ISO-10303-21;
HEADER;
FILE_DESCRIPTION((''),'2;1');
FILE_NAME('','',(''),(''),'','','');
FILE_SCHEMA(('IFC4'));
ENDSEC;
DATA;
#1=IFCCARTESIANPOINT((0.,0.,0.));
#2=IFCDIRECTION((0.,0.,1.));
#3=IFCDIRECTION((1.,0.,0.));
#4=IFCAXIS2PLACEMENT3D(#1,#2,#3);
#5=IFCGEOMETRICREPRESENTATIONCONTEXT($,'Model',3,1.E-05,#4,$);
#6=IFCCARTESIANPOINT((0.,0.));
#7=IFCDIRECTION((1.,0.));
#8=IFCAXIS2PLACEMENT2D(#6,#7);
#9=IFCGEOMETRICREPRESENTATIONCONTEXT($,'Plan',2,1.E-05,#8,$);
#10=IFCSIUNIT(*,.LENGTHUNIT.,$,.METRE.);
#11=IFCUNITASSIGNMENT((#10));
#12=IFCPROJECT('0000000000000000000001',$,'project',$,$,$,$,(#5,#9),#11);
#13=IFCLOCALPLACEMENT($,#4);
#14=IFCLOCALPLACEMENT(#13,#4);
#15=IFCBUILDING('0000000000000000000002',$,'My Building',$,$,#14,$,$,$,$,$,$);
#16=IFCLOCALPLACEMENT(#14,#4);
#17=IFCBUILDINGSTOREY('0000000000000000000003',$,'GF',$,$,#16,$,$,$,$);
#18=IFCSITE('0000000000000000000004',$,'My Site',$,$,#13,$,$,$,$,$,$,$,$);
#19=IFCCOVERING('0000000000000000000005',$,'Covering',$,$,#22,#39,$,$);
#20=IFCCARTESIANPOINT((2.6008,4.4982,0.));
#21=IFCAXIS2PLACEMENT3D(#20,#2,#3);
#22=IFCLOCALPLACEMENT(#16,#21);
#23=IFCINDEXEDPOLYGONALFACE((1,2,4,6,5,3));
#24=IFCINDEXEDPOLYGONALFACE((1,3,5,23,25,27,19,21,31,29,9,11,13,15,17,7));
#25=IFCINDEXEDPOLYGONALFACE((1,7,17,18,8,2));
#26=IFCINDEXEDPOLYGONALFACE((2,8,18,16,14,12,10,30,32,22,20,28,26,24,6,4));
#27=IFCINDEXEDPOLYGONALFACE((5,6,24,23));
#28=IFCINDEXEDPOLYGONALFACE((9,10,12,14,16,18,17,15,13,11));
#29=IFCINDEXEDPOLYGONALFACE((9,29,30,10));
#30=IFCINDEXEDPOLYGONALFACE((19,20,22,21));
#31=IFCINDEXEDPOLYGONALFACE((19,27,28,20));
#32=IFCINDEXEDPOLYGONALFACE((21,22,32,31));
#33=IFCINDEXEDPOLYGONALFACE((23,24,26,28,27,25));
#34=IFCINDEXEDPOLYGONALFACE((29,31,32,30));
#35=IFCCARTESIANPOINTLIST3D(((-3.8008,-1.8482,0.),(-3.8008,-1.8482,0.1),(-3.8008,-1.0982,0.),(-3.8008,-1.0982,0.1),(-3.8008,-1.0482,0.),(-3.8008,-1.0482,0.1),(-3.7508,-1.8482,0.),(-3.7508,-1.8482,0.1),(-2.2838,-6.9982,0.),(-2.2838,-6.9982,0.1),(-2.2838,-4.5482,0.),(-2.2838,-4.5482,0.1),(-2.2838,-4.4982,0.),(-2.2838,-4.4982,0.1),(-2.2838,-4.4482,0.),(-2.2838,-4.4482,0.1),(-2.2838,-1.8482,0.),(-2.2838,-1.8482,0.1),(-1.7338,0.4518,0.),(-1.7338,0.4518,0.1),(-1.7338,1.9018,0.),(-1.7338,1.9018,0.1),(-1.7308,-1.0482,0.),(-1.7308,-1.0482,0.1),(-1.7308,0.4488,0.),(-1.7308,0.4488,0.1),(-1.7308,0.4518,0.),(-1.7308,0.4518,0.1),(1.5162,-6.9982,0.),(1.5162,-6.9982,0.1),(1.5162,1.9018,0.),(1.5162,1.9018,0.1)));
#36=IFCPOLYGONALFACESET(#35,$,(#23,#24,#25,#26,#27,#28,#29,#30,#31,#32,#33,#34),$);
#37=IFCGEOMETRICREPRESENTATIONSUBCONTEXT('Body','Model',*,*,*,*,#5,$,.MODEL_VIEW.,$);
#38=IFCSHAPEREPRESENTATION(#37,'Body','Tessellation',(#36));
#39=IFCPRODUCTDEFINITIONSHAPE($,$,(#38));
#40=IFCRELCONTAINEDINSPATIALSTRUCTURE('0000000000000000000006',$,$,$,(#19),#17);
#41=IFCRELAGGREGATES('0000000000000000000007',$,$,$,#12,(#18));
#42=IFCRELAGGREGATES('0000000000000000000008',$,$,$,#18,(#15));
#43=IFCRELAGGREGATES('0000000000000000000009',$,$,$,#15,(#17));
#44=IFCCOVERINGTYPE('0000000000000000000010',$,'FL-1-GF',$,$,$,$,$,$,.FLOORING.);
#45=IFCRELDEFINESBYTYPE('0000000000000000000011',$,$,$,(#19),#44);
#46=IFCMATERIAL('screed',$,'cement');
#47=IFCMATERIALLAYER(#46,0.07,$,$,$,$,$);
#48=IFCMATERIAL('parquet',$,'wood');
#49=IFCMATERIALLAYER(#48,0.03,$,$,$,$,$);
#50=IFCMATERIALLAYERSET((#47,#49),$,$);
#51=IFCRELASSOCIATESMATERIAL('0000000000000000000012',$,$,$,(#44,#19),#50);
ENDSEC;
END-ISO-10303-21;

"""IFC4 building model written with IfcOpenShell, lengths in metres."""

from ifc_helpers import new_model, si_unit, frame, origin_with_axes, origin_2d_with_axis, place, context, subcontext, project, spatial, line, indexed_curve, outline, extrude, material, layer, layer_set, layer_usage, type_object, element, save


model = new_model("IFC4")

# Units and contexts
model_context = context("Model", 3, precision=1e-05, world=origin_with_axes())
plan_context = context("Plan", 2, precision=1e-05, world=origin_2d_with_axis())
body_context_1 = subcontext(model_context, "Body", "Model", "MODEL_VIEW")
ifc_project = project(units=[si_unit("LENGTHUNIT", "METRE")], contexts=[model_context, plan_context])

# Site, building, storey
site_placement = place(None, origin_with_axes())
site = spatial("IfcSite", under=ifc_project, at=site_placement, Name="My Site")
building_placement = place(site_placement, origin_with_axes())
building = spatial("IfcBuilding", under=site, at=building_placement, Name="My Building")
storey_placement = place(building_placement, origin_with_axes())
storey = spatial("IfcBuildingStorey", under=building, at=storey_placement, Name="GF")

# Covering
ifc_material_1 = material(Name="screed", Category="cement")
ifc_layer_1 = layer(ifc_material_1, 0.07)
ifc_material_2 = material(Name="parquet", Category="wood")
ifc_layer_2 = layer(ifc_material_2, 0.03)
ifc_layer_set_1 = layer_set([ifc_layer_1, ifc_layer_2])
ifc_layer_usage_1 = layer_usage(ifc_layer_set_1, "AXIS3", "POSITIVE", 0.0)
covering_type = type_object("IfcCoveringType", Name="FL-1-GF", PredefinedType="FLOORING", material=ifc_layer_set_1)
covering_placement = place(storey_placement, frame((2.6008, 4.4982, 0.0), z_axis=(0.0, 0.0, 1.0), x_axis=(1.0, 0.0, 0.0)))
element("IfcCovering", 1, at=covering_placement, inside=storey, type_object=covering_type, material=ifc_layer_usage_1, Name="Covering", context=body_context_1, shape_type="SweptSolid", body=[
    extrude(outline(indexed_curve([(-1.7338, 1.9018), (1.5162, 1.9018), (1.5162, -6.9982), (-2.2838, -6.9982), (-2.2838, -4.5482), (-2.2838, -4.4982), (-2.2838, -4.4482), (-2.2838, -1.8482), (-3.7508, -1.8482), (-3.8008, -1.8482), (-3.8008, -1.0982), (-3.8008, -1.0482), (-1.7308, -1.0482), (-1.7308, 0.4488), (-1.7308, 0.4518), (-1.7338, 0.4518)], segments=[line(1, 2, 3, 4, 5, 6, 7, 8, 9, 10, 11, 12, 13, 14, 15, 16, 1)])), origin_with_axes(), (0.0, 0.0, 1.0), 0.1),
])

save(model, "model.ifc")
